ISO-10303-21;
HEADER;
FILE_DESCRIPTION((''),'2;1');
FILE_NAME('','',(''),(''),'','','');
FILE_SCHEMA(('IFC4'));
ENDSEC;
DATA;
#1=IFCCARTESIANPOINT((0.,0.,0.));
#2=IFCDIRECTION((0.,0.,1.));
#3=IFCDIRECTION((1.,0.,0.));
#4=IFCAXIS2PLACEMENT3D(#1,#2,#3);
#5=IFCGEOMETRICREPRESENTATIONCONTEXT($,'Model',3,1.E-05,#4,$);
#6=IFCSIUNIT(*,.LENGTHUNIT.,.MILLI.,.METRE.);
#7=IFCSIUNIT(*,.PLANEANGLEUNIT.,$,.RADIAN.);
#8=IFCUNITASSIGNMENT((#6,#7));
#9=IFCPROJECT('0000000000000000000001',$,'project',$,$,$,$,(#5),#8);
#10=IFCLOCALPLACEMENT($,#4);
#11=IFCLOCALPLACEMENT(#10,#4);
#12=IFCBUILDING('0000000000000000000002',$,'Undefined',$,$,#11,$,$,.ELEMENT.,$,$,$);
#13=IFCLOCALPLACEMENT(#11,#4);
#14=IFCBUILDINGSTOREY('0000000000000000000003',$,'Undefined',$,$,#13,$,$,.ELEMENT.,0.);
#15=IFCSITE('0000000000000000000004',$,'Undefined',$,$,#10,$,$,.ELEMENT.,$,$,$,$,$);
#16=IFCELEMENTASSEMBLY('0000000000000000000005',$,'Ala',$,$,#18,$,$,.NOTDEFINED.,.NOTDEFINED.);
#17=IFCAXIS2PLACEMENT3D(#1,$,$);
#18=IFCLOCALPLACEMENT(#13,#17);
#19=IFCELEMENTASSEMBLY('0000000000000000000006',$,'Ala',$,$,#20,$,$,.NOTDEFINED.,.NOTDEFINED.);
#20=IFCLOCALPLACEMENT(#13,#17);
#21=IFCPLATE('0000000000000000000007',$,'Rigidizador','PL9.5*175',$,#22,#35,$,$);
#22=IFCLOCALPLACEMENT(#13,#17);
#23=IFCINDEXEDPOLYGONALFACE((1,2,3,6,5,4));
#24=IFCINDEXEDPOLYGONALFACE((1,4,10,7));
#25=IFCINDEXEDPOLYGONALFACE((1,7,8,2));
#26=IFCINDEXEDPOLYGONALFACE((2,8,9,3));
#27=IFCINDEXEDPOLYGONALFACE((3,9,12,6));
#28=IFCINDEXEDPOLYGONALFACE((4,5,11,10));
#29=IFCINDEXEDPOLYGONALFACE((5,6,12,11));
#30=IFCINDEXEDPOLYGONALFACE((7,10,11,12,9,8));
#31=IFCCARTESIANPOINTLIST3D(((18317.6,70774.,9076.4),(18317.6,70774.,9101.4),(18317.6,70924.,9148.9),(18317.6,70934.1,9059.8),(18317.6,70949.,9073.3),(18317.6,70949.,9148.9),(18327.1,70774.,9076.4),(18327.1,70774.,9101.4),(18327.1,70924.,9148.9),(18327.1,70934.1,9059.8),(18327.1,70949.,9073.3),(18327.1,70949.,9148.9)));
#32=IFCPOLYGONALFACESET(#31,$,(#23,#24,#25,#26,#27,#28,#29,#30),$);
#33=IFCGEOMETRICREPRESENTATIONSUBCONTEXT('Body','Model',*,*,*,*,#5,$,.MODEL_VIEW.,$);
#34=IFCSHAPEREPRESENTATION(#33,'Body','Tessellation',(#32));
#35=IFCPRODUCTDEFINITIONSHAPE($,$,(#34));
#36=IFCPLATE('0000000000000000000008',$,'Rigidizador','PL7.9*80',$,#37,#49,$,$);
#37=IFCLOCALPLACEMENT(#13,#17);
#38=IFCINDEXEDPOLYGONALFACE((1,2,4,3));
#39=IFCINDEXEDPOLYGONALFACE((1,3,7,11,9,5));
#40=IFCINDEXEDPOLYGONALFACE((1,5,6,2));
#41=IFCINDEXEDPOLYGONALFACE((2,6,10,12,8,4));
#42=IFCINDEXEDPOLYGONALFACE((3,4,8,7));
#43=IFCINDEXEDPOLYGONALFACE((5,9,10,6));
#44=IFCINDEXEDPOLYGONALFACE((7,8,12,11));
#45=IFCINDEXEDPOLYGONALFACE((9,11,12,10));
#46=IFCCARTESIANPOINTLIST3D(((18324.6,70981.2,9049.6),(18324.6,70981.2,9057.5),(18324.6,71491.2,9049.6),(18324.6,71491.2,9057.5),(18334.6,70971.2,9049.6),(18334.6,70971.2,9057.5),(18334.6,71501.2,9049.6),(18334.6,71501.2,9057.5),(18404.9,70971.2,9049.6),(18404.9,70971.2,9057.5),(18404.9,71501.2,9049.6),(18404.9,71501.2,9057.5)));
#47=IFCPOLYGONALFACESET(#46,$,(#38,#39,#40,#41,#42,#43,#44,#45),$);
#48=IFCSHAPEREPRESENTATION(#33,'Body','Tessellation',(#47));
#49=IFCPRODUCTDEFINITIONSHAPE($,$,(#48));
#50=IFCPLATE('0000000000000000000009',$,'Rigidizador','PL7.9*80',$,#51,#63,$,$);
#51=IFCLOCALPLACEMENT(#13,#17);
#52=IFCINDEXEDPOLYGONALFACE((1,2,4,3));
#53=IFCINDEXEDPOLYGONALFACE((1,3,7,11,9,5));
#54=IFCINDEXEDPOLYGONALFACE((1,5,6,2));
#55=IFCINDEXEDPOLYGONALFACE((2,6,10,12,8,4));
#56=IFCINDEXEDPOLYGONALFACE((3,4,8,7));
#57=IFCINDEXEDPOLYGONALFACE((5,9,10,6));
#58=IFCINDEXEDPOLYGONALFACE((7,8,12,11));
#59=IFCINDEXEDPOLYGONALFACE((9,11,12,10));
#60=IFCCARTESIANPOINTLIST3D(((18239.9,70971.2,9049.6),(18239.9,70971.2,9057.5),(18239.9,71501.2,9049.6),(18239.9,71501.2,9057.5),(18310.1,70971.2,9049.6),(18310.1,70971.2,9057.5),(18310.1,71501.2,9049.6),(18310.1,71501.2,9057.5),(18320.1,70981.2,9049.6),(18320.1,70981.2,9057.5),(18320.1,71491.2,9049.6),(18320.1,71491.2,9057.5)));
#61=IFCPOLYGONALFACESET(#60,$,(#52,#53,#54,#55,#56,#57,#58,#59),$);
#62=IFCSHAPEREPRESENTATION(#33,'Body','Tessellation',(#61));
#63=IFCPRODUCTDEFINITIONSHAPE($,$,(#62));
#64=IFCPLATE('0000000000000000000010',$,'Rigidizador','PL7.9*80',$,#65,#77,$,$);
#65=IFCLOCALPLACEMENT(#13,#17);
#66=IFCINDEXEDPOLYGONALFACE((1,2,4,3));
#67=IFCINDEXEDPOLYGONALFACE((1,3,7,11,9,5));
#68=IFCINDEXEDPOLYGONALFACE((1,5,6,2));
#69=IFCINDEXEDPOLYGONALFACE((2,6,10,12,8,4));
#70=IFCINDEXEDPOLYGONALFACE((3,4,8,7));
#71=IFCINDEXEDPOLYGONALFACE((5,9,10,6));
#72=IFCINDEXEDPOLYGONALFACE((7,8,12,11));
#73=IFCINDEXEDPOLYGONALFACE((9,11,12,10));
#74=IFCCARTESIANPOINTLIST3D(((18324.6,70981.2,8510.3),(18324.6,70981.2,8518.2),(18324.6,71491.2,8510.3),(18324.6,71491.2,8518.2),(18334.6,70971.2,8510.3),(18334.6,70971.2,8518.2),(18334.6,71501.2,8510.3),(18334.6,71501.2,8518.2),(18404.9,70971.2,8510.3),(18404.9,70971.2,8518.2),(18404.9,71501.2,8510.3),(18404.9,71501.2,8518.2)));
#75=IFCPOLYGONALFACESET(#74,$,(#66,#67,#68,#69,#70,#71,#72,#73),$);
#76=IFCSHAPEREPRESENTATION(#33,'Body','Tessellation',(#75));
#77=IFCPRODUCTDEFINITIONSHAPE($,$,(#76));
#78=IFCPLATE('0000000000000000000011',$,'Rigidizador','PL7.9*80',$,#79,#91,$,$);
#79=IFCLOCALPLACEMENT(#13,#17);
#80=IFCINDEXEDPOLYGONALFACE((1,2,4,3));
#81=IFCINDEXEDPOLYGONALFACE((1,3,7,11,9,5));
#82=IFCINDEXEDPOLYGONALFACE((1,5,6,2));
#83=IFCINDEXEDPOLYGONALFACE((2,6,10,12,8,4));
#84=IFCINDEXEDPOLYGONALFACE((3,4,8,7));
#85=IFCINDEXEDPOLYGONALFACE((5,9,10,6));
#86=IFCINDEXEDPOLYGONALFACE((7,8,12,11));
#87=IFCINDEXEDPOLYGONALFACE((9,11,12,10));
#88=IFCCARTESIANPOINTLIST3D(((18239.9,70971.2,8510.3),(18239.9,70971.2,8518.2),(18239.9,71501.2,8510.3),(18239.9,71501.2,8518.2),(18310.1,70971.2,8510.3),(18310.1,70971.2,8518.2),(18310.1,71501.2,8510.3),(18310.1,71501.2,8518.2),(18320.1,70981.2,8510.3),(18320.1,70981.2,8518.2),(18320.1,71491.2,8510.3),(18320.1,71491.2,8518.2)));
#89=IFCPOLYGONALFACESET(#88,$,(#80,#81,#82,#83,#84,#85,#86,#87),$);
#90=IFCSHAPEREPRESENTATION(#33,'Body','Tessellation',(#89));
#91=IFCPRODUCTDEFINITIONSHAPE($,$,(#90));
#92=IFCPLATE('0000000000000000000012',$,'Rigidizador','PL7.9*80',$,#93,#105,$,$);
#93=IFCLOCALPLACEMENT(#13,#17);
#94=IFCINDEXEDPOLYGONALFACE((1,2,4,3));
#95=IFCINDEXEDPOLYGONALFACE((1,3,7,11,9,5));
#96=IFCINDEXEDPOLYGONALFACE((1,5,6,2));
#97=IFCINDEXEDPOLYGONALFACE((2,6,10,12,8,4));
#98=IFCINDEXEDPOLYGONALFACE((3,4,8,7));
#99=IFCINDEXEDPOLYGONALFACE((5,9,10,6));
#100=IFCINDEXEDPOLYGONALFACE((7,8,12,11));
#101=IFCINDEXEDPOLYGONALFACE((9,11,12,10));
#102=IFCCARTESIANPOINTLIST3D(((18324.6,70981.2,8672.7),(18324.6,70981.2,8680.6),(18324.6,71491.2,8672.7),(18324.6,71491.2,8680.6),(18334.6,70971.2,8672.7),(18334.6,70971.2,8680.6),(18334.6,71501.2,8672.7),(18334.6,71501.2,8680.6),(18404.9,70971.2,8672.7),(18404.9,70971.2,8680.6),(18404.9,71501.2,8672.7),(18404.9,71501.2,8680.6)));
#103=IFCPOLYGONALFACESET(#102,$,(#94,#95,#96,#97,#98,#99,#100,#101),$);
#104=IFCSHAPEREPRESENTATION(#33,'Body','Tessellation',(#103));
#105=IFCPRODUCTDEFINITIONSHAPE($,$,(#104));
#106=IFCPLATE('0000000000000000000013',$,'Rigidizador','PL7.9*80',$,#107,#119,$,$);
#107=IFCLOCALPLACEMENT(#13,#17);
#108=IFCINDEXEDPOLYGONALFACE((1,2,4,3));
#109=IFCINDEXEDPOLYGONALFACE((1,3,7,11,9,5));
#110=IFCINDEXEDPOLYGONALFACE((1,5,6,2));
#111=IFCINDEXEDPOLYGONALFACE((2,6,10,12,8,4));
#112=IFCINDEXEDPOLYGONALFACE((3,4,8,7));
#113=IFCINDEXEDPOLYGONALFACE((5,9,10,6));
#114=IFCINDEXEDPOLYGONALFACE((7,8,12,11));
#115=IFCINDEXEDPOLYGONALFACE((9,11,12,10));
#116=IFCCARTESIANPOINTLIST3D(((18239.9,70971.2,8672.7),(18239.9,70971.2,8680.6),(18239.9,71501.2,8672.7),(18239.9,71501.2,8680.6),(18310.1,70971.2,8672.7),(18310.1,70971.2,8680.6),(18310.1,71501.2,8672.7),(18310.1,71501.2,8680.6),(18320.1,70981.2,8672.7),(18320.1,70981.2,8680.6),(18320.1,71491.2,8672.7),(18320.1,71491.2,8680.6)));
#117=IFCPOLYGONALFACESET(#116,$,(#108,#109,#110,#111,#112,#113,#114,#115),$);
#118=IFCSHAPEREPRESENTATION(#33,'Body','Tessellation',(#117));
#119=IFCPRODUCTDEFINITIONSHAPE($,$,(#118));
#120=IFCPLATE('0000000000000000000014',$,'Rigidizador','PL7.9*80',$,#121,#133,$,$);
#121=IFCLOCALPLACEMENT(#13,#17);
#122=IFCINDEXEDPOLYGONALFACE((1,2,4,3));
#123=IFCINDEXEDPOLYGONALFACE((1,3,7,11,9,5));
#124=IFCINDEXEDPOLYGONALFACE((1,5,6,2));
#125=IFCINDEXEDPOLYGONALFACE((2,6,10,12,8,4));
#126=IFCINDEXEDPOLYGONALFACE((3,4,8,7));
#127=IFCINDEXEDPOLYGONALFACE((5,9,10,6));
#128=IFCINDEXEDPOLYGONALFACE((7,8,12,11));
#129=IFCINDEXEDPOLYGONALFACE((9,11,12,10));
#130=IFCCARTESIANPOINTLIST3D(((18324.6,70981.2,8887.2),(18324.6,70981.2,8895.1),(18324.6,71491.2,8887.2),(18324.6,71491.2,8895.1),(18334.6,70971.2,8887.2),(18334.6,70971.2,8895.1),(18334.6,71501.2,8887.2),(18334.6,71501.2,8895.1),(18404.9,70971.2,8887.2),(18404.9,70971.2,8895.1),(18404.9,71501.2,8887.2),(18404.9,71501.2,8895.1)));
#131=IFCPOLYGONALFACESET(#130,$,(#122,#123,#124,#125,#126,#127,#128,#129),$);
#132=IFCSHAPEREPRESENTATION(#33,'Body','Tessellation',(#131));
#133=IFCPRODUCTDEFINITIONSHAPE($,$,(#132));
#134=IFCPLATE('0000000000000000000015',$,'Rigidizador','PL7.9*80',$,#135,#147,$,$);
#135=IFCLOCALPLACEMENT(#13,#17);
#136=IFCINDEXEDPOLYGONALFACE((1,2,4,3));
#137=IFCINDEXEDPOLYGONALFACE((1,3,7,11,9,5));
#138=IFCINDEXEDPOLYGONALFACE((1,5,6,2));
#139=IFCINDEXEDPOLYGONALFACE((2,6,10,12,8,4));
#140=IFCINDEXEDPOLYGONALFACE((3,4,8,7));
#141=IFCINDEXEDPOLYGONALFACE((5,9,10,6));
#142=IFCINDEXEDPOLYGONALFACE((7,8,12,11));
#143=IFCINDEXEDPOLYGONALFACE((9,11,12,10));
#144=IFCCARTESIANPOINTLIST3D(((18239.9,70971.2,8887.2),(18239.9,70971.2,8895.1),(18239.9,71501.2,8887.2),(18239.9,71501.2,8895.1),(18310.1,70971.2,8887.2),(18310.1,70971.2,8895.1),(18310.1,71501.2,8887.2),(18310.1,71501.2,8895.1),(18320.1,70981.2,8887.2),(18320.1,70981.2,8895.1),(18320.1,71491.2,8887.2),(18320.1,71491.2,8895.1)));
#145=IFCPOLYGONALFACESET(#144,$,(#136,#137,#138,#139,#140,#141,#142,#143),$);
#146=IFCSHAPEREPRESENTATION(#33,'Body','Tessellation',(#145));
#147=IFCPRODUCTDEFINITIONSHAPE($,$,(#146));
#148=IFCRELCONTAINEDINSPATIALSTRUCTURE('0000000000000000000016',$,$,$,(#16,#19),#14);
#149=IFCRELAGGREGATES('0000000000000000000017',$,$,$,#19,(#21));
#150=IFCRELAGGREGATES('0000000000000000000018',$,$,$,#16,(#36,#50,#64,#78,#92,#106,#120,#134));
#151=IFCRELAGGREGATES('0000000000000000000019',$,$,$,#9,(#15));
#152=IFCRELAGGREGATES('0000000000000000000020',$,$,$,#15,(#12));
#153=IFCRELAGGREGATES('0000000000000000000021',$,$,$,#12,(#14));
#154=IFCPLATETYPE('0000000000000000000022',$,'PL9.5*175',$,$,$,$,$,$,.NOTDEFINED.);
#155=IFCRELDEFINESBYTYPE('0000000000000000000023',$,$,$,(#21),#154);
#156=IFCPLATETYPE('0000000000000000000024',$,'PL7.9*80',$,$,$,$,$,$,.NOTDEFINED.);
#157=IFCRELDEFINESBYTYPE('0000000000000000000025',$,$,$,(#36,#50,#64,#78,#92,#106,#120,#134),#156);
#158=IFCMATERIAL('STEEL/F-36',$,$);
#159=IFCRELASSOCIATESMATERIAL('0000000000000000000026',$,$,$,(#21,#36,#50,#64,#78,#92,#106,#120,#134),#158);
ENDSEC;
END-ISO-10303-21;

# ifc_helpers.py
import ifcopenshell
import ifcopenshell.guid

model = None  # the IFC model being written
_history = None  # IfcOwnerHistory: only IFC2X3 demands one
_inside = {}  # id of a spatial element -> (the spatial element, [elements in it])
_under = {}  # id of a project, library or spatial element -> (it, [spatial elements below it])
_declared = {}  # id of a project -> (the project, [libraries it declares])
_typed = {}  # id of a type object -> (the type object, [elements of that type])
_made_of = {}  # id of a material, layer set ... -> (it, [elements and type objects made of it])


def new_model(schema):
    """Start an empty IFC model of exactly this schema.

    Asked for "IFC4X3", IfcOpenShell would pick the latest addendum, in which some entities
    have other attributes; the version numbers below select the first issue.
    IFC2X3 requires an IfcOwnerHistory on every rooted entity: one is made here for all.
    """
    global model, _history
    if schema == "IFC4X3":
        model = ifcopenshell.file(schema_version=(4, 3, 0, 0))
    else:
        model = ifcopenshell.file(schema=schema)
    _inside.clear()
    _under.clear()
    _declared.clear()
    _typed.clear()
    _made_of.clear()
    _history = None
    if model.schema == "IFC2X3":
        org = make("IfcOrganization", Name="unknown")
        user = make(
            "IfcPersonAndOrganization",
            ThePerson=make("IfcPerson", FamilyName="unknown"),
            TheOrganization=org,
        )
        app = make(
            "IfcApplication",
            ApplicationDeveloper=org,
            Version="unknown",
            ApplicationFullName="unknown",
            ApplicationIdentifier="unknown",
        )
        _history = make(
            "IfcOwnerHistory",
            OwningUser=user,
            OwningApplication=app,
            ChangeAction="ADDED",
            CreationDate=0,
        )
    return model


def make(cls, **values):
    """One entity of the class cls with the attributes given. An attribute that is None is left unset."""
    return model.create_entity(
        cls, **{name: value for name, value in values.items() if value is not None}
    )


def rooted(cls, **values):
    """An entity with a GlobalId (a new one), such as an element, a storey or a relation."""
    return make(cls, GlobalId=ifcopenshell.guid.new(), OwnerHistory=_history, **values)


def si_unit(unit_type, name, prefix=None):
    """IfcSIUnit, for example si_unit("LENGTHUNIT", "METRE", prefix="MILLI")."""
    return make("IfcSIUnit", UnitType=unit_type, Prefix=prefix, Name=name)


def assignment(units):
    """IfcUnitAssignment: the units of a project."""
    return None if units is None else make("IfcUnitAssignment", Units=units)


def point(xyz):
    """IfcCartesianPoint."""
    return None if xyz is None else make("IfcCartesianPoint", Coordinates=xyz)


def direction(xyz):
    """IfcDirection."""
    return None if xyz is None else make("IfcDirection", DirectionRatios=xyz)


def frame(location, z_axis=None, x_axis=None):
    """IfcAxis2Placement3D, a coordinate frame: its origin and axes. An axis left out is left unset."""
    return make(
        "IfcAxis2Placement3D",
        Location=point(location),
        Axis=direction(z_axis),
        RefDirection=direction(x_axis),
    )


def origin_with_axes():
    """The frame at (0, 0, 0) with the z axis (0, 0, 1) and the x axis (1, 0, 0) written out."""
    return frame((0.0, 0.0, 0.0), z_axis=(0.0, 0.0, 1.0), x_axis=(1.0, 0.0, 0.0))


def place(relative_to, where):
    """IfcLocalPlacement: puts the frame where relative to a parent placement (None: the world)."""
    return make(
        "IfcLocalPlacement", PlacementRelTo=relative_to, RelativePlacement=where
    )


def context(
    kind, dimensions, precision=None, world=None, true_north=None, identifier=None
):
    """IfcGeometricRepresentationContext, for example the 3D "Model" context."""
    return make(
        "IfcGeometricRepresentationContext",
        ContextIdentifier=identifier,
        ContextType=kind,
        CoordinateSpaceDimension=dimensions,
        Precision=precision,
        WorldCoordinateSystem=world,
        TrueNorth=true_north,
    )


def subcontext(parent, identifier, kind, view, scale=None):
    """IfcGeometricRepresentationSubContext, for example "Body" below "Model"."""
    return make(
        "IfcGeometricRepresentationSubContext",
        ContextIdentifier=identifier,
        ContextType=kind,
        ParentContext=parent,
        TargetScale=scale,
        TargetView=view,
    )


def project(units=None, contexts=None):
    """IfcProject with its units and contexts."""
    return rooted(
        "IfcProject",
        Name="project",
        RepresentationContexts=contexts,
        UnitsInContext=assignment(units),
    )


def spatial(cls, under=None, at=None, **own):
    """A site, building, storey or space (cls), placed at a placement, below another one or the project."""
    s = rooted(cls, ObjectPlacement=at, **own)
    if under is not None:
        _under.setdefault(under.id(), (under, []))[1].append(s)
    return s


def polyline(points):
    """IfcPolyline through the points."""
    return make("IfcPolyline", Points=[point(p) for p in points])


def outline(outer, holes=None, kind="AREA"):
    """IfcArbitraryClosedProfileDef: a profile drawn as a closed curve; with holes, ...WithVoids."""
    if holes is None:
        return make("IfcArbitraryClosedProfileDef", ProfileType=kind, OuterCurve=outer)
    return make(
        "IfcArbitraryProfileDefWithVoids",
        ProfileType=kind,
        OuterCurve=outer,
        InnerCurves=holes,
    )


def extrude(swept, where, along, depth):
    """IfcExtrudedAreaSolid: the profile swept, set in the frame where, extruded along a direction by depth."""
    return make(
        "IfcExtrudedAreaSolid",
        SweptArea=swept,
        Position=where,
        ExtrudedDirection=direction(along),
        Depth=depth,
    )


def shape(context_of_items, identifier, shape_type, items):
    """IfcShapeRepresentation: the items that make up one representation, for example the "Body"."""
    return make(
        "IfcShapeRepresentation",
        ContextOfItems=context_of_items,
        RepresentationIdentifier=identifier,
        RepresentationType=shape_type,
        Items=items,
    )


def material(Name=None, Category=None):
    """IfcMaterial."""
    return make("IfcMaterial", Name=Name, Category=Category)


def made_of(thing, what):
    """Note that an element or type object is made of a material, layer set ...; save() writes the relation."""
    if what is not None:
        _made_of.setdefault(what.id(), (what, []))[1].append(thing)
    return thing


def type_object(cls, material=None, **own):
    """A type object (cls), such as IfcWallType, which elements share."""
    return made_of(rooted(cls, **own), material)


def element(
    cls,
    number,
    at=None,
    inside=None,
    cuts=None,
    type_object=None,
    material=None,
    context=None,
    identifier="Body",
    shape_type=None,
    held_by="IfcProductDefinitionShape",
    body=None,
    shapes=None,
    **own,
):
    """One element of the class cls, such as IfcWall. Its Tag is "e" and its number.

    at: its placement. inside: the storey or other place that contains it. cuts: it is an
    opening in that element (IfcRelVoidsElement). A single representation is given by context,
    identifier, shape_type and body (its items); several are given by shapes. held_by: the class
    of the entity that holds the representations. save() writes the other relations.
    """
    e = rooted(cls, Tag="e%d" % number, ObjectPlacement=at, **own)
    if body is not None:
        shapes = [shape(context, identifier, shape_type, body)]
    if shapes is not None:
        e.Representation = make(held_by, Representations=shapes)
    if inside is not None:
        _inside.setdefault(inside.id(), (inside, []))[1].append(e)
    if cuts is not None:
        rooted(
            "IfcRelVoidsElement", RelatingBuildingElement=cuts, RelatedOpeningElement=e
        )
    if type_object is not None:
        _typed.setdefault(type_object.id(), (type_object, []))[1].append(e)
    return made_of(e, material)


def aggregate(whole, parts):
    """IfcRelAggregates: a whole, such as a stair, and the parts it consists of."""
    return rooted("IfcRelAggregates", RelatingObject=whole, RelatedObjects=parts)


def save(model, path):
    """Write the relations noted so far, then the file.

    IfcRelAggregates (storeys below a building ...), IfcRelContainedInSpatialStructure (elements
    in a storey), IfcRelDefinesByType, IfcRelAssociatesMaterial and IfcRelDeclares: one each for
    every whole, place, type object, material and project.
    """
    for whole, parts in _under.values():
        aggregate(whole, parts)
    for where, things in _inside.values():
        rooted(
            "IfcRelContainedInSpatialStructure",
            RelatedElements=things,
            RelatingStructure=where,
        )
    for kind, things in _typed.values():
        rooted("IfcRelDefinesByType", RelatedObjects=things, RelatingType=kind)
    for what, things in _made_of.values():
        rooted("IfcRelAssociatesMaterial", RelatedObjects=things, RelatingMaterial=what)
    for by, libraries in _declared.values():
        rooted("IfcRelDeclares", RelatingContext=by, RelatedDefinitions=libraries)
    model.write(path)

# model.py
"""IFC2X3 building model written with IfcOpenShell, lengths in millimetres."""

from ifc_helpers import new_model, si_unit, frame, origin_with_axes, place, context, subcontext, project, spatial, polyline, outline, extrude, material, type_object, element, aggregate, save


model = new_model("IFC2X3")

# Units and contexts
model_context = context("Model", 3, precision=1e-05, world=origin_with_axes())
body_context = subcontext(model_context, "Body", "Model", "MODEL_VIEW")
ifc_project = project(units=[si_unit("LENGTHUNIT", "METRE", prefix="MILLI"), si_unit("PLANEANGLEUNIT", "RADIAN")], contexts=[model_context])

# Site, building, storey
site_placement = place(None, origin_with_axes())
site = spatial("IfcSite", under=ifc_project, at=site_placement, Name="Undefined", CompositionType="ELEMENT")
building_placement = place(site_placement, origin_with_axes())
building = spatial("IfcBuilding", under=site, at=building_placement, Name="Undefined", CompositionType="ELEMENT")
storey_placement = place(building_placement, origin_with_axes())
storey = spatial("IfcBuildingStorey", under=building, at=storey_placement, Name="Undefined", CompositionType="ELEMENT", Elevation=0.0)

# Element assembly
assembly_1_placement = place(storey_placement, origin_with_axes())
assembly_1 = element("IfcElementAssembly", 1, at=assembly_1_placement, inside=storey, Name="Ala", AssemblyPlace="NOTDEFINED", PredefinedType="NOTDEFINED")

# Element assembly, plate
assembly_2_placement = place(storey_placement, origin_with_axes())
assembly_2 = element("IfcElementAssembly", 2, at=assembly_2_placement, inside=storey, Name="Ala", AssemblyPlace="NOTDEFINED", PredefinedType="NOTDEFINED")
ifc_material_1 = material(Name="STEEL/F-36")
plate_type_1 = type_object("IfcPlateType", Name="PL9.5*175", PredefinedType="NOTDEFINED")
plate_1_placement = place(assembly_2_placement, frame((18322.4, 70924.0, 9148.9), z_axis=(-1.0, 0.0, 0.0), x_axis=(0.0, 1.0, 0.0)))
plate_1 = element("IfcPlate", 3, at=plate_1_placement, type_object=plate_type_1, material=ifc_material_1, Name="Rigidizador", Description="PL9.5*175", context=body_context, shape_type="SweptSolid", body=[
    extrude(outline(polyline([(0.0, 0.0), (25.0, 0.0), (25.0, 75.6), (10.1, 89.1), (-150.0, 72.5), (-150.0, 47.5), (0.0, 0.0)])), frame((0.0, 0.0, -4.8), z_axis=(0.0, 0.0, 1.0), x_axis=(1.0, 0.0, 0.0)), (0.0, 0.0, 1.0), 9.5),
])
aggregate(assembly_2, [plate_1])

# Plates
plate_type_2 = type_object("IfcPlateType", Name="PL7.9*80", PredefinedType="NOTDEFINED")
plate_2_placement = place(assembly_1_placement, frame((18324.6, 70971.2, 9053.5), z_axis=(0.0, 0.0, 1.0), x_axis=(1.0, 0.0, 0.0)))
plate_2 = element("IfcPlate", 4, at=plate_2_placement, type_object=plate_type_2, material=ifc_material_1, Name="Rigidizador", Description="PL7.9*80", context=body_context, shape_type="SweptSolid", body=[
    extrude(outline(polyline([(0.0, 10.0), (10.0, 0.0), (80.2, 0.0), (80.2, 530.0), (10.0, 530.0), (0.0, 520.0), (0.0, 10.0)])), frame((0.0, 0.0, -4.0), z_axis=(0.0, 0.0, 1.0), x_axis=(1.0, 0.0, 0.0)), (0.0, 0.0, 1.0), 7.9),
])
plate_3_placement = place(assembly_1_placement, frame((18320.1, 70971.2, 9053.5), z_axis=(0.0, 0.0, -1.0), x_axis=(-1.0, 0.0, 0.0)))
plate_3 = element("IfcPlate", 5, at=plate_3_placement, type_object=plate_type_2, material=ifc_material_1, Name="Rigidizador", Description="PL7.9*80", context=body_context, shape_type="SweptSolid", body=[
    extrude(outline(polyline([(0.0, 10.0), (10.0, 0.0), (80.2, 0.0), (80.2, 530.0), (10.0, 530.0), (0.0, 520.0), (0.0, 10.0)])), frame((0.0, 0.0, -4.0), z_axis=(0.0, 0.0, 1.0), x_axis=(1.0, 0.0, 0.0)), (0.0, 0.0, 1.0), 7.9),
])
plate_4_placement = place(assembly_1_placement, frame((18324.6, 70971.2, 8514.3), z_axis=(0.0, 0.0, 1.0), x_axis=(1.0, 0.0, 0.0)))
plate_4 = element("IfcPlate", 6, at=plate_4_placement, type_object=plate_type_2, material=ifc_material_1, Name="Rigidizador", Description="PL7.9*80", context=body_context, shape_type="SweptSolid", body=[
    extrude(outline(polyline([(0.0, 10.0), (10.0, 0.0), (80.2, 0.0), (80.2, 530.0), (10.0, 530.0), (0.0, 520.0), (0.0, 10.0)])), frame((0.0, 0.0, -4.0), z_axis=(0.0, 0.0, 1.0), x_axis=(1.0, 0.0, 0.0)), (0.0, 0.0, 1.0), 7.9),
])
plate_5_placement = place(assembly_1_placement, frame((18320.1, 70971.2, 8514.3), z_axis=(0.0, 0.0, -1.0), x_axis=(-1.0, 0.0, 0.0)))
plate_5 = element("IfcPlate", 7, at=plate_5_placement, type_object=plate_type_2, material=ifc_material_1, Name="Rigidizador", Description="PL7.9*80", context=body_context, shape_type="SweptSolid", body=[
    extrude(outline(polyline([(0.0, 10.0), (10.0, 0.0), (80.2, 0.0), (80.2, 530.0), (10.0, 530.0), (0.0, 520.0), (0.0, 10.0)])), frame((0.0, 0.0, -4.0), z_axis=(0.0, 0.0, 1.0), x_axis=(1.0, 0.0, 0.0)), (0.0, 0.0, 1.0), 7.9),
])
plate_6_placement = place(assembly_1_placement, frame((18324.6, 70971.2, 8676.6), z_axis=(0.0, 0.0, 1.0), x_axis=(1.0, 0.0, 0.0)))
plate_6 = element("IfcPlate", 8, at=plate_6_placement, type_object=plate_type_2, material=ifc_material_1, Name="Rigidizador", Description="PL7.9*80", context=body_context, shape_type="SweptSolid", body=[
    extrude(outline(polyline([(0.0, 10.0), (10.0, 0.0), (80.2, 0.0), (80.2, 530.0), (10.0, 530.0), (0.0, 520.0), (0.0, 10.0)])), frame((0.0, 0.0, -4.0), z_axis=(0.0, 0.0, 1.0), x_axis=(1.0, 0.0, 0.0)), (0.0, 0.0, 1.0), 7.9),
])
plate_7_placement = place(assembly_1_placement, frame((18320.1, 70971.2, 8676.6), z_axis=(0.0, 0.0, -1.0), x_axis=(-1.0, 0.0, 0.0)))
plate_7 = element("IfcPlate", 9, at=plate_7_placement, type_object=plate_type_2, material=ifc_material_1, Name="Rigidizador", Description="PL7.9*80", context=body_context, shape_type="SweptSolid", body=[
    extrude(outline(polyline([(0.0, 10.0), (10.0, 0.0), (80.2, 0.0), (80.2, 530.0), (10.0, 530.0), (0.0, 520.0), (0.0, 10.0)])), frame((0.0, 0.0, -4.0), z_axis=(0.0, 0.0, 1.0), x_axis=(1.0, 0.0, 0.0)), (0.0, 0.0, 1.0), 7.9),
])
plate_8_placement = place(assembly_1_placement, frame((18324.6, 70971.2, 8891.1), z_axis=(0.0, 0.0, 1.0), x_axis=(1.0, 0.0, 0.0)))
plate_8 = element("IfcPlate", 10, at=plate_8_placement, type_object=plate_type_2, material=ifc_material_1, Name="Rigidizador", Description="PL7.9*80", context=body_context, shape_type="SweptSolid", body=[
    extrude(outline(polyline([(0.0, 10.0), (10.0, 0.0), (80.2, 0.0), (80.2, 530.0), (10.0, 530.0), (0.0, 520.0), (0.0, 10.0)])), frame((0.0, 0.0, -4.0), z_axis=(0.0, 0.0, 1.0), x_axis=(1.0, 0.0, 0.0)), (0.0, 0.0, 1.0), 7.9),
])
plate_9_placement = place(assembly_1_placement, frame((18320.1, 70971.2, 8891.1), z_axis=(0.0, 0.0, -1.0), x_axis=(-1.0, 0.0, 0.0)))
plate_9 = element("IfcPlate", 11, at=plate_9_placement, type_object=plate_type_2, material=ifc_material_1, Name="Rigidizador", Description="PL7.9*80", context=body_context, shape_type="SweptSolid", body=[
    extrude(outline(polyline([(0.0, 10.0), (10.0, 0.0), (80.2, 0.0), (80.2, 530.0), (10.0, 530.0), (0.0, 520.0), (0.0, 10.0)])), frame((0.0, 0.0, -4.0), z_axis=(0.0, 0.0, 1.0), x_axis=(1.0, 0.0, 0.0)), (0.0, 0.0, 1.0), 7.9),
])

aggregate(assembly_1, [plate_2, plate_3, plate_4, plate_5, plate_6, plate_7, plate_8, plate_9])

save(model, "model.ifc")
